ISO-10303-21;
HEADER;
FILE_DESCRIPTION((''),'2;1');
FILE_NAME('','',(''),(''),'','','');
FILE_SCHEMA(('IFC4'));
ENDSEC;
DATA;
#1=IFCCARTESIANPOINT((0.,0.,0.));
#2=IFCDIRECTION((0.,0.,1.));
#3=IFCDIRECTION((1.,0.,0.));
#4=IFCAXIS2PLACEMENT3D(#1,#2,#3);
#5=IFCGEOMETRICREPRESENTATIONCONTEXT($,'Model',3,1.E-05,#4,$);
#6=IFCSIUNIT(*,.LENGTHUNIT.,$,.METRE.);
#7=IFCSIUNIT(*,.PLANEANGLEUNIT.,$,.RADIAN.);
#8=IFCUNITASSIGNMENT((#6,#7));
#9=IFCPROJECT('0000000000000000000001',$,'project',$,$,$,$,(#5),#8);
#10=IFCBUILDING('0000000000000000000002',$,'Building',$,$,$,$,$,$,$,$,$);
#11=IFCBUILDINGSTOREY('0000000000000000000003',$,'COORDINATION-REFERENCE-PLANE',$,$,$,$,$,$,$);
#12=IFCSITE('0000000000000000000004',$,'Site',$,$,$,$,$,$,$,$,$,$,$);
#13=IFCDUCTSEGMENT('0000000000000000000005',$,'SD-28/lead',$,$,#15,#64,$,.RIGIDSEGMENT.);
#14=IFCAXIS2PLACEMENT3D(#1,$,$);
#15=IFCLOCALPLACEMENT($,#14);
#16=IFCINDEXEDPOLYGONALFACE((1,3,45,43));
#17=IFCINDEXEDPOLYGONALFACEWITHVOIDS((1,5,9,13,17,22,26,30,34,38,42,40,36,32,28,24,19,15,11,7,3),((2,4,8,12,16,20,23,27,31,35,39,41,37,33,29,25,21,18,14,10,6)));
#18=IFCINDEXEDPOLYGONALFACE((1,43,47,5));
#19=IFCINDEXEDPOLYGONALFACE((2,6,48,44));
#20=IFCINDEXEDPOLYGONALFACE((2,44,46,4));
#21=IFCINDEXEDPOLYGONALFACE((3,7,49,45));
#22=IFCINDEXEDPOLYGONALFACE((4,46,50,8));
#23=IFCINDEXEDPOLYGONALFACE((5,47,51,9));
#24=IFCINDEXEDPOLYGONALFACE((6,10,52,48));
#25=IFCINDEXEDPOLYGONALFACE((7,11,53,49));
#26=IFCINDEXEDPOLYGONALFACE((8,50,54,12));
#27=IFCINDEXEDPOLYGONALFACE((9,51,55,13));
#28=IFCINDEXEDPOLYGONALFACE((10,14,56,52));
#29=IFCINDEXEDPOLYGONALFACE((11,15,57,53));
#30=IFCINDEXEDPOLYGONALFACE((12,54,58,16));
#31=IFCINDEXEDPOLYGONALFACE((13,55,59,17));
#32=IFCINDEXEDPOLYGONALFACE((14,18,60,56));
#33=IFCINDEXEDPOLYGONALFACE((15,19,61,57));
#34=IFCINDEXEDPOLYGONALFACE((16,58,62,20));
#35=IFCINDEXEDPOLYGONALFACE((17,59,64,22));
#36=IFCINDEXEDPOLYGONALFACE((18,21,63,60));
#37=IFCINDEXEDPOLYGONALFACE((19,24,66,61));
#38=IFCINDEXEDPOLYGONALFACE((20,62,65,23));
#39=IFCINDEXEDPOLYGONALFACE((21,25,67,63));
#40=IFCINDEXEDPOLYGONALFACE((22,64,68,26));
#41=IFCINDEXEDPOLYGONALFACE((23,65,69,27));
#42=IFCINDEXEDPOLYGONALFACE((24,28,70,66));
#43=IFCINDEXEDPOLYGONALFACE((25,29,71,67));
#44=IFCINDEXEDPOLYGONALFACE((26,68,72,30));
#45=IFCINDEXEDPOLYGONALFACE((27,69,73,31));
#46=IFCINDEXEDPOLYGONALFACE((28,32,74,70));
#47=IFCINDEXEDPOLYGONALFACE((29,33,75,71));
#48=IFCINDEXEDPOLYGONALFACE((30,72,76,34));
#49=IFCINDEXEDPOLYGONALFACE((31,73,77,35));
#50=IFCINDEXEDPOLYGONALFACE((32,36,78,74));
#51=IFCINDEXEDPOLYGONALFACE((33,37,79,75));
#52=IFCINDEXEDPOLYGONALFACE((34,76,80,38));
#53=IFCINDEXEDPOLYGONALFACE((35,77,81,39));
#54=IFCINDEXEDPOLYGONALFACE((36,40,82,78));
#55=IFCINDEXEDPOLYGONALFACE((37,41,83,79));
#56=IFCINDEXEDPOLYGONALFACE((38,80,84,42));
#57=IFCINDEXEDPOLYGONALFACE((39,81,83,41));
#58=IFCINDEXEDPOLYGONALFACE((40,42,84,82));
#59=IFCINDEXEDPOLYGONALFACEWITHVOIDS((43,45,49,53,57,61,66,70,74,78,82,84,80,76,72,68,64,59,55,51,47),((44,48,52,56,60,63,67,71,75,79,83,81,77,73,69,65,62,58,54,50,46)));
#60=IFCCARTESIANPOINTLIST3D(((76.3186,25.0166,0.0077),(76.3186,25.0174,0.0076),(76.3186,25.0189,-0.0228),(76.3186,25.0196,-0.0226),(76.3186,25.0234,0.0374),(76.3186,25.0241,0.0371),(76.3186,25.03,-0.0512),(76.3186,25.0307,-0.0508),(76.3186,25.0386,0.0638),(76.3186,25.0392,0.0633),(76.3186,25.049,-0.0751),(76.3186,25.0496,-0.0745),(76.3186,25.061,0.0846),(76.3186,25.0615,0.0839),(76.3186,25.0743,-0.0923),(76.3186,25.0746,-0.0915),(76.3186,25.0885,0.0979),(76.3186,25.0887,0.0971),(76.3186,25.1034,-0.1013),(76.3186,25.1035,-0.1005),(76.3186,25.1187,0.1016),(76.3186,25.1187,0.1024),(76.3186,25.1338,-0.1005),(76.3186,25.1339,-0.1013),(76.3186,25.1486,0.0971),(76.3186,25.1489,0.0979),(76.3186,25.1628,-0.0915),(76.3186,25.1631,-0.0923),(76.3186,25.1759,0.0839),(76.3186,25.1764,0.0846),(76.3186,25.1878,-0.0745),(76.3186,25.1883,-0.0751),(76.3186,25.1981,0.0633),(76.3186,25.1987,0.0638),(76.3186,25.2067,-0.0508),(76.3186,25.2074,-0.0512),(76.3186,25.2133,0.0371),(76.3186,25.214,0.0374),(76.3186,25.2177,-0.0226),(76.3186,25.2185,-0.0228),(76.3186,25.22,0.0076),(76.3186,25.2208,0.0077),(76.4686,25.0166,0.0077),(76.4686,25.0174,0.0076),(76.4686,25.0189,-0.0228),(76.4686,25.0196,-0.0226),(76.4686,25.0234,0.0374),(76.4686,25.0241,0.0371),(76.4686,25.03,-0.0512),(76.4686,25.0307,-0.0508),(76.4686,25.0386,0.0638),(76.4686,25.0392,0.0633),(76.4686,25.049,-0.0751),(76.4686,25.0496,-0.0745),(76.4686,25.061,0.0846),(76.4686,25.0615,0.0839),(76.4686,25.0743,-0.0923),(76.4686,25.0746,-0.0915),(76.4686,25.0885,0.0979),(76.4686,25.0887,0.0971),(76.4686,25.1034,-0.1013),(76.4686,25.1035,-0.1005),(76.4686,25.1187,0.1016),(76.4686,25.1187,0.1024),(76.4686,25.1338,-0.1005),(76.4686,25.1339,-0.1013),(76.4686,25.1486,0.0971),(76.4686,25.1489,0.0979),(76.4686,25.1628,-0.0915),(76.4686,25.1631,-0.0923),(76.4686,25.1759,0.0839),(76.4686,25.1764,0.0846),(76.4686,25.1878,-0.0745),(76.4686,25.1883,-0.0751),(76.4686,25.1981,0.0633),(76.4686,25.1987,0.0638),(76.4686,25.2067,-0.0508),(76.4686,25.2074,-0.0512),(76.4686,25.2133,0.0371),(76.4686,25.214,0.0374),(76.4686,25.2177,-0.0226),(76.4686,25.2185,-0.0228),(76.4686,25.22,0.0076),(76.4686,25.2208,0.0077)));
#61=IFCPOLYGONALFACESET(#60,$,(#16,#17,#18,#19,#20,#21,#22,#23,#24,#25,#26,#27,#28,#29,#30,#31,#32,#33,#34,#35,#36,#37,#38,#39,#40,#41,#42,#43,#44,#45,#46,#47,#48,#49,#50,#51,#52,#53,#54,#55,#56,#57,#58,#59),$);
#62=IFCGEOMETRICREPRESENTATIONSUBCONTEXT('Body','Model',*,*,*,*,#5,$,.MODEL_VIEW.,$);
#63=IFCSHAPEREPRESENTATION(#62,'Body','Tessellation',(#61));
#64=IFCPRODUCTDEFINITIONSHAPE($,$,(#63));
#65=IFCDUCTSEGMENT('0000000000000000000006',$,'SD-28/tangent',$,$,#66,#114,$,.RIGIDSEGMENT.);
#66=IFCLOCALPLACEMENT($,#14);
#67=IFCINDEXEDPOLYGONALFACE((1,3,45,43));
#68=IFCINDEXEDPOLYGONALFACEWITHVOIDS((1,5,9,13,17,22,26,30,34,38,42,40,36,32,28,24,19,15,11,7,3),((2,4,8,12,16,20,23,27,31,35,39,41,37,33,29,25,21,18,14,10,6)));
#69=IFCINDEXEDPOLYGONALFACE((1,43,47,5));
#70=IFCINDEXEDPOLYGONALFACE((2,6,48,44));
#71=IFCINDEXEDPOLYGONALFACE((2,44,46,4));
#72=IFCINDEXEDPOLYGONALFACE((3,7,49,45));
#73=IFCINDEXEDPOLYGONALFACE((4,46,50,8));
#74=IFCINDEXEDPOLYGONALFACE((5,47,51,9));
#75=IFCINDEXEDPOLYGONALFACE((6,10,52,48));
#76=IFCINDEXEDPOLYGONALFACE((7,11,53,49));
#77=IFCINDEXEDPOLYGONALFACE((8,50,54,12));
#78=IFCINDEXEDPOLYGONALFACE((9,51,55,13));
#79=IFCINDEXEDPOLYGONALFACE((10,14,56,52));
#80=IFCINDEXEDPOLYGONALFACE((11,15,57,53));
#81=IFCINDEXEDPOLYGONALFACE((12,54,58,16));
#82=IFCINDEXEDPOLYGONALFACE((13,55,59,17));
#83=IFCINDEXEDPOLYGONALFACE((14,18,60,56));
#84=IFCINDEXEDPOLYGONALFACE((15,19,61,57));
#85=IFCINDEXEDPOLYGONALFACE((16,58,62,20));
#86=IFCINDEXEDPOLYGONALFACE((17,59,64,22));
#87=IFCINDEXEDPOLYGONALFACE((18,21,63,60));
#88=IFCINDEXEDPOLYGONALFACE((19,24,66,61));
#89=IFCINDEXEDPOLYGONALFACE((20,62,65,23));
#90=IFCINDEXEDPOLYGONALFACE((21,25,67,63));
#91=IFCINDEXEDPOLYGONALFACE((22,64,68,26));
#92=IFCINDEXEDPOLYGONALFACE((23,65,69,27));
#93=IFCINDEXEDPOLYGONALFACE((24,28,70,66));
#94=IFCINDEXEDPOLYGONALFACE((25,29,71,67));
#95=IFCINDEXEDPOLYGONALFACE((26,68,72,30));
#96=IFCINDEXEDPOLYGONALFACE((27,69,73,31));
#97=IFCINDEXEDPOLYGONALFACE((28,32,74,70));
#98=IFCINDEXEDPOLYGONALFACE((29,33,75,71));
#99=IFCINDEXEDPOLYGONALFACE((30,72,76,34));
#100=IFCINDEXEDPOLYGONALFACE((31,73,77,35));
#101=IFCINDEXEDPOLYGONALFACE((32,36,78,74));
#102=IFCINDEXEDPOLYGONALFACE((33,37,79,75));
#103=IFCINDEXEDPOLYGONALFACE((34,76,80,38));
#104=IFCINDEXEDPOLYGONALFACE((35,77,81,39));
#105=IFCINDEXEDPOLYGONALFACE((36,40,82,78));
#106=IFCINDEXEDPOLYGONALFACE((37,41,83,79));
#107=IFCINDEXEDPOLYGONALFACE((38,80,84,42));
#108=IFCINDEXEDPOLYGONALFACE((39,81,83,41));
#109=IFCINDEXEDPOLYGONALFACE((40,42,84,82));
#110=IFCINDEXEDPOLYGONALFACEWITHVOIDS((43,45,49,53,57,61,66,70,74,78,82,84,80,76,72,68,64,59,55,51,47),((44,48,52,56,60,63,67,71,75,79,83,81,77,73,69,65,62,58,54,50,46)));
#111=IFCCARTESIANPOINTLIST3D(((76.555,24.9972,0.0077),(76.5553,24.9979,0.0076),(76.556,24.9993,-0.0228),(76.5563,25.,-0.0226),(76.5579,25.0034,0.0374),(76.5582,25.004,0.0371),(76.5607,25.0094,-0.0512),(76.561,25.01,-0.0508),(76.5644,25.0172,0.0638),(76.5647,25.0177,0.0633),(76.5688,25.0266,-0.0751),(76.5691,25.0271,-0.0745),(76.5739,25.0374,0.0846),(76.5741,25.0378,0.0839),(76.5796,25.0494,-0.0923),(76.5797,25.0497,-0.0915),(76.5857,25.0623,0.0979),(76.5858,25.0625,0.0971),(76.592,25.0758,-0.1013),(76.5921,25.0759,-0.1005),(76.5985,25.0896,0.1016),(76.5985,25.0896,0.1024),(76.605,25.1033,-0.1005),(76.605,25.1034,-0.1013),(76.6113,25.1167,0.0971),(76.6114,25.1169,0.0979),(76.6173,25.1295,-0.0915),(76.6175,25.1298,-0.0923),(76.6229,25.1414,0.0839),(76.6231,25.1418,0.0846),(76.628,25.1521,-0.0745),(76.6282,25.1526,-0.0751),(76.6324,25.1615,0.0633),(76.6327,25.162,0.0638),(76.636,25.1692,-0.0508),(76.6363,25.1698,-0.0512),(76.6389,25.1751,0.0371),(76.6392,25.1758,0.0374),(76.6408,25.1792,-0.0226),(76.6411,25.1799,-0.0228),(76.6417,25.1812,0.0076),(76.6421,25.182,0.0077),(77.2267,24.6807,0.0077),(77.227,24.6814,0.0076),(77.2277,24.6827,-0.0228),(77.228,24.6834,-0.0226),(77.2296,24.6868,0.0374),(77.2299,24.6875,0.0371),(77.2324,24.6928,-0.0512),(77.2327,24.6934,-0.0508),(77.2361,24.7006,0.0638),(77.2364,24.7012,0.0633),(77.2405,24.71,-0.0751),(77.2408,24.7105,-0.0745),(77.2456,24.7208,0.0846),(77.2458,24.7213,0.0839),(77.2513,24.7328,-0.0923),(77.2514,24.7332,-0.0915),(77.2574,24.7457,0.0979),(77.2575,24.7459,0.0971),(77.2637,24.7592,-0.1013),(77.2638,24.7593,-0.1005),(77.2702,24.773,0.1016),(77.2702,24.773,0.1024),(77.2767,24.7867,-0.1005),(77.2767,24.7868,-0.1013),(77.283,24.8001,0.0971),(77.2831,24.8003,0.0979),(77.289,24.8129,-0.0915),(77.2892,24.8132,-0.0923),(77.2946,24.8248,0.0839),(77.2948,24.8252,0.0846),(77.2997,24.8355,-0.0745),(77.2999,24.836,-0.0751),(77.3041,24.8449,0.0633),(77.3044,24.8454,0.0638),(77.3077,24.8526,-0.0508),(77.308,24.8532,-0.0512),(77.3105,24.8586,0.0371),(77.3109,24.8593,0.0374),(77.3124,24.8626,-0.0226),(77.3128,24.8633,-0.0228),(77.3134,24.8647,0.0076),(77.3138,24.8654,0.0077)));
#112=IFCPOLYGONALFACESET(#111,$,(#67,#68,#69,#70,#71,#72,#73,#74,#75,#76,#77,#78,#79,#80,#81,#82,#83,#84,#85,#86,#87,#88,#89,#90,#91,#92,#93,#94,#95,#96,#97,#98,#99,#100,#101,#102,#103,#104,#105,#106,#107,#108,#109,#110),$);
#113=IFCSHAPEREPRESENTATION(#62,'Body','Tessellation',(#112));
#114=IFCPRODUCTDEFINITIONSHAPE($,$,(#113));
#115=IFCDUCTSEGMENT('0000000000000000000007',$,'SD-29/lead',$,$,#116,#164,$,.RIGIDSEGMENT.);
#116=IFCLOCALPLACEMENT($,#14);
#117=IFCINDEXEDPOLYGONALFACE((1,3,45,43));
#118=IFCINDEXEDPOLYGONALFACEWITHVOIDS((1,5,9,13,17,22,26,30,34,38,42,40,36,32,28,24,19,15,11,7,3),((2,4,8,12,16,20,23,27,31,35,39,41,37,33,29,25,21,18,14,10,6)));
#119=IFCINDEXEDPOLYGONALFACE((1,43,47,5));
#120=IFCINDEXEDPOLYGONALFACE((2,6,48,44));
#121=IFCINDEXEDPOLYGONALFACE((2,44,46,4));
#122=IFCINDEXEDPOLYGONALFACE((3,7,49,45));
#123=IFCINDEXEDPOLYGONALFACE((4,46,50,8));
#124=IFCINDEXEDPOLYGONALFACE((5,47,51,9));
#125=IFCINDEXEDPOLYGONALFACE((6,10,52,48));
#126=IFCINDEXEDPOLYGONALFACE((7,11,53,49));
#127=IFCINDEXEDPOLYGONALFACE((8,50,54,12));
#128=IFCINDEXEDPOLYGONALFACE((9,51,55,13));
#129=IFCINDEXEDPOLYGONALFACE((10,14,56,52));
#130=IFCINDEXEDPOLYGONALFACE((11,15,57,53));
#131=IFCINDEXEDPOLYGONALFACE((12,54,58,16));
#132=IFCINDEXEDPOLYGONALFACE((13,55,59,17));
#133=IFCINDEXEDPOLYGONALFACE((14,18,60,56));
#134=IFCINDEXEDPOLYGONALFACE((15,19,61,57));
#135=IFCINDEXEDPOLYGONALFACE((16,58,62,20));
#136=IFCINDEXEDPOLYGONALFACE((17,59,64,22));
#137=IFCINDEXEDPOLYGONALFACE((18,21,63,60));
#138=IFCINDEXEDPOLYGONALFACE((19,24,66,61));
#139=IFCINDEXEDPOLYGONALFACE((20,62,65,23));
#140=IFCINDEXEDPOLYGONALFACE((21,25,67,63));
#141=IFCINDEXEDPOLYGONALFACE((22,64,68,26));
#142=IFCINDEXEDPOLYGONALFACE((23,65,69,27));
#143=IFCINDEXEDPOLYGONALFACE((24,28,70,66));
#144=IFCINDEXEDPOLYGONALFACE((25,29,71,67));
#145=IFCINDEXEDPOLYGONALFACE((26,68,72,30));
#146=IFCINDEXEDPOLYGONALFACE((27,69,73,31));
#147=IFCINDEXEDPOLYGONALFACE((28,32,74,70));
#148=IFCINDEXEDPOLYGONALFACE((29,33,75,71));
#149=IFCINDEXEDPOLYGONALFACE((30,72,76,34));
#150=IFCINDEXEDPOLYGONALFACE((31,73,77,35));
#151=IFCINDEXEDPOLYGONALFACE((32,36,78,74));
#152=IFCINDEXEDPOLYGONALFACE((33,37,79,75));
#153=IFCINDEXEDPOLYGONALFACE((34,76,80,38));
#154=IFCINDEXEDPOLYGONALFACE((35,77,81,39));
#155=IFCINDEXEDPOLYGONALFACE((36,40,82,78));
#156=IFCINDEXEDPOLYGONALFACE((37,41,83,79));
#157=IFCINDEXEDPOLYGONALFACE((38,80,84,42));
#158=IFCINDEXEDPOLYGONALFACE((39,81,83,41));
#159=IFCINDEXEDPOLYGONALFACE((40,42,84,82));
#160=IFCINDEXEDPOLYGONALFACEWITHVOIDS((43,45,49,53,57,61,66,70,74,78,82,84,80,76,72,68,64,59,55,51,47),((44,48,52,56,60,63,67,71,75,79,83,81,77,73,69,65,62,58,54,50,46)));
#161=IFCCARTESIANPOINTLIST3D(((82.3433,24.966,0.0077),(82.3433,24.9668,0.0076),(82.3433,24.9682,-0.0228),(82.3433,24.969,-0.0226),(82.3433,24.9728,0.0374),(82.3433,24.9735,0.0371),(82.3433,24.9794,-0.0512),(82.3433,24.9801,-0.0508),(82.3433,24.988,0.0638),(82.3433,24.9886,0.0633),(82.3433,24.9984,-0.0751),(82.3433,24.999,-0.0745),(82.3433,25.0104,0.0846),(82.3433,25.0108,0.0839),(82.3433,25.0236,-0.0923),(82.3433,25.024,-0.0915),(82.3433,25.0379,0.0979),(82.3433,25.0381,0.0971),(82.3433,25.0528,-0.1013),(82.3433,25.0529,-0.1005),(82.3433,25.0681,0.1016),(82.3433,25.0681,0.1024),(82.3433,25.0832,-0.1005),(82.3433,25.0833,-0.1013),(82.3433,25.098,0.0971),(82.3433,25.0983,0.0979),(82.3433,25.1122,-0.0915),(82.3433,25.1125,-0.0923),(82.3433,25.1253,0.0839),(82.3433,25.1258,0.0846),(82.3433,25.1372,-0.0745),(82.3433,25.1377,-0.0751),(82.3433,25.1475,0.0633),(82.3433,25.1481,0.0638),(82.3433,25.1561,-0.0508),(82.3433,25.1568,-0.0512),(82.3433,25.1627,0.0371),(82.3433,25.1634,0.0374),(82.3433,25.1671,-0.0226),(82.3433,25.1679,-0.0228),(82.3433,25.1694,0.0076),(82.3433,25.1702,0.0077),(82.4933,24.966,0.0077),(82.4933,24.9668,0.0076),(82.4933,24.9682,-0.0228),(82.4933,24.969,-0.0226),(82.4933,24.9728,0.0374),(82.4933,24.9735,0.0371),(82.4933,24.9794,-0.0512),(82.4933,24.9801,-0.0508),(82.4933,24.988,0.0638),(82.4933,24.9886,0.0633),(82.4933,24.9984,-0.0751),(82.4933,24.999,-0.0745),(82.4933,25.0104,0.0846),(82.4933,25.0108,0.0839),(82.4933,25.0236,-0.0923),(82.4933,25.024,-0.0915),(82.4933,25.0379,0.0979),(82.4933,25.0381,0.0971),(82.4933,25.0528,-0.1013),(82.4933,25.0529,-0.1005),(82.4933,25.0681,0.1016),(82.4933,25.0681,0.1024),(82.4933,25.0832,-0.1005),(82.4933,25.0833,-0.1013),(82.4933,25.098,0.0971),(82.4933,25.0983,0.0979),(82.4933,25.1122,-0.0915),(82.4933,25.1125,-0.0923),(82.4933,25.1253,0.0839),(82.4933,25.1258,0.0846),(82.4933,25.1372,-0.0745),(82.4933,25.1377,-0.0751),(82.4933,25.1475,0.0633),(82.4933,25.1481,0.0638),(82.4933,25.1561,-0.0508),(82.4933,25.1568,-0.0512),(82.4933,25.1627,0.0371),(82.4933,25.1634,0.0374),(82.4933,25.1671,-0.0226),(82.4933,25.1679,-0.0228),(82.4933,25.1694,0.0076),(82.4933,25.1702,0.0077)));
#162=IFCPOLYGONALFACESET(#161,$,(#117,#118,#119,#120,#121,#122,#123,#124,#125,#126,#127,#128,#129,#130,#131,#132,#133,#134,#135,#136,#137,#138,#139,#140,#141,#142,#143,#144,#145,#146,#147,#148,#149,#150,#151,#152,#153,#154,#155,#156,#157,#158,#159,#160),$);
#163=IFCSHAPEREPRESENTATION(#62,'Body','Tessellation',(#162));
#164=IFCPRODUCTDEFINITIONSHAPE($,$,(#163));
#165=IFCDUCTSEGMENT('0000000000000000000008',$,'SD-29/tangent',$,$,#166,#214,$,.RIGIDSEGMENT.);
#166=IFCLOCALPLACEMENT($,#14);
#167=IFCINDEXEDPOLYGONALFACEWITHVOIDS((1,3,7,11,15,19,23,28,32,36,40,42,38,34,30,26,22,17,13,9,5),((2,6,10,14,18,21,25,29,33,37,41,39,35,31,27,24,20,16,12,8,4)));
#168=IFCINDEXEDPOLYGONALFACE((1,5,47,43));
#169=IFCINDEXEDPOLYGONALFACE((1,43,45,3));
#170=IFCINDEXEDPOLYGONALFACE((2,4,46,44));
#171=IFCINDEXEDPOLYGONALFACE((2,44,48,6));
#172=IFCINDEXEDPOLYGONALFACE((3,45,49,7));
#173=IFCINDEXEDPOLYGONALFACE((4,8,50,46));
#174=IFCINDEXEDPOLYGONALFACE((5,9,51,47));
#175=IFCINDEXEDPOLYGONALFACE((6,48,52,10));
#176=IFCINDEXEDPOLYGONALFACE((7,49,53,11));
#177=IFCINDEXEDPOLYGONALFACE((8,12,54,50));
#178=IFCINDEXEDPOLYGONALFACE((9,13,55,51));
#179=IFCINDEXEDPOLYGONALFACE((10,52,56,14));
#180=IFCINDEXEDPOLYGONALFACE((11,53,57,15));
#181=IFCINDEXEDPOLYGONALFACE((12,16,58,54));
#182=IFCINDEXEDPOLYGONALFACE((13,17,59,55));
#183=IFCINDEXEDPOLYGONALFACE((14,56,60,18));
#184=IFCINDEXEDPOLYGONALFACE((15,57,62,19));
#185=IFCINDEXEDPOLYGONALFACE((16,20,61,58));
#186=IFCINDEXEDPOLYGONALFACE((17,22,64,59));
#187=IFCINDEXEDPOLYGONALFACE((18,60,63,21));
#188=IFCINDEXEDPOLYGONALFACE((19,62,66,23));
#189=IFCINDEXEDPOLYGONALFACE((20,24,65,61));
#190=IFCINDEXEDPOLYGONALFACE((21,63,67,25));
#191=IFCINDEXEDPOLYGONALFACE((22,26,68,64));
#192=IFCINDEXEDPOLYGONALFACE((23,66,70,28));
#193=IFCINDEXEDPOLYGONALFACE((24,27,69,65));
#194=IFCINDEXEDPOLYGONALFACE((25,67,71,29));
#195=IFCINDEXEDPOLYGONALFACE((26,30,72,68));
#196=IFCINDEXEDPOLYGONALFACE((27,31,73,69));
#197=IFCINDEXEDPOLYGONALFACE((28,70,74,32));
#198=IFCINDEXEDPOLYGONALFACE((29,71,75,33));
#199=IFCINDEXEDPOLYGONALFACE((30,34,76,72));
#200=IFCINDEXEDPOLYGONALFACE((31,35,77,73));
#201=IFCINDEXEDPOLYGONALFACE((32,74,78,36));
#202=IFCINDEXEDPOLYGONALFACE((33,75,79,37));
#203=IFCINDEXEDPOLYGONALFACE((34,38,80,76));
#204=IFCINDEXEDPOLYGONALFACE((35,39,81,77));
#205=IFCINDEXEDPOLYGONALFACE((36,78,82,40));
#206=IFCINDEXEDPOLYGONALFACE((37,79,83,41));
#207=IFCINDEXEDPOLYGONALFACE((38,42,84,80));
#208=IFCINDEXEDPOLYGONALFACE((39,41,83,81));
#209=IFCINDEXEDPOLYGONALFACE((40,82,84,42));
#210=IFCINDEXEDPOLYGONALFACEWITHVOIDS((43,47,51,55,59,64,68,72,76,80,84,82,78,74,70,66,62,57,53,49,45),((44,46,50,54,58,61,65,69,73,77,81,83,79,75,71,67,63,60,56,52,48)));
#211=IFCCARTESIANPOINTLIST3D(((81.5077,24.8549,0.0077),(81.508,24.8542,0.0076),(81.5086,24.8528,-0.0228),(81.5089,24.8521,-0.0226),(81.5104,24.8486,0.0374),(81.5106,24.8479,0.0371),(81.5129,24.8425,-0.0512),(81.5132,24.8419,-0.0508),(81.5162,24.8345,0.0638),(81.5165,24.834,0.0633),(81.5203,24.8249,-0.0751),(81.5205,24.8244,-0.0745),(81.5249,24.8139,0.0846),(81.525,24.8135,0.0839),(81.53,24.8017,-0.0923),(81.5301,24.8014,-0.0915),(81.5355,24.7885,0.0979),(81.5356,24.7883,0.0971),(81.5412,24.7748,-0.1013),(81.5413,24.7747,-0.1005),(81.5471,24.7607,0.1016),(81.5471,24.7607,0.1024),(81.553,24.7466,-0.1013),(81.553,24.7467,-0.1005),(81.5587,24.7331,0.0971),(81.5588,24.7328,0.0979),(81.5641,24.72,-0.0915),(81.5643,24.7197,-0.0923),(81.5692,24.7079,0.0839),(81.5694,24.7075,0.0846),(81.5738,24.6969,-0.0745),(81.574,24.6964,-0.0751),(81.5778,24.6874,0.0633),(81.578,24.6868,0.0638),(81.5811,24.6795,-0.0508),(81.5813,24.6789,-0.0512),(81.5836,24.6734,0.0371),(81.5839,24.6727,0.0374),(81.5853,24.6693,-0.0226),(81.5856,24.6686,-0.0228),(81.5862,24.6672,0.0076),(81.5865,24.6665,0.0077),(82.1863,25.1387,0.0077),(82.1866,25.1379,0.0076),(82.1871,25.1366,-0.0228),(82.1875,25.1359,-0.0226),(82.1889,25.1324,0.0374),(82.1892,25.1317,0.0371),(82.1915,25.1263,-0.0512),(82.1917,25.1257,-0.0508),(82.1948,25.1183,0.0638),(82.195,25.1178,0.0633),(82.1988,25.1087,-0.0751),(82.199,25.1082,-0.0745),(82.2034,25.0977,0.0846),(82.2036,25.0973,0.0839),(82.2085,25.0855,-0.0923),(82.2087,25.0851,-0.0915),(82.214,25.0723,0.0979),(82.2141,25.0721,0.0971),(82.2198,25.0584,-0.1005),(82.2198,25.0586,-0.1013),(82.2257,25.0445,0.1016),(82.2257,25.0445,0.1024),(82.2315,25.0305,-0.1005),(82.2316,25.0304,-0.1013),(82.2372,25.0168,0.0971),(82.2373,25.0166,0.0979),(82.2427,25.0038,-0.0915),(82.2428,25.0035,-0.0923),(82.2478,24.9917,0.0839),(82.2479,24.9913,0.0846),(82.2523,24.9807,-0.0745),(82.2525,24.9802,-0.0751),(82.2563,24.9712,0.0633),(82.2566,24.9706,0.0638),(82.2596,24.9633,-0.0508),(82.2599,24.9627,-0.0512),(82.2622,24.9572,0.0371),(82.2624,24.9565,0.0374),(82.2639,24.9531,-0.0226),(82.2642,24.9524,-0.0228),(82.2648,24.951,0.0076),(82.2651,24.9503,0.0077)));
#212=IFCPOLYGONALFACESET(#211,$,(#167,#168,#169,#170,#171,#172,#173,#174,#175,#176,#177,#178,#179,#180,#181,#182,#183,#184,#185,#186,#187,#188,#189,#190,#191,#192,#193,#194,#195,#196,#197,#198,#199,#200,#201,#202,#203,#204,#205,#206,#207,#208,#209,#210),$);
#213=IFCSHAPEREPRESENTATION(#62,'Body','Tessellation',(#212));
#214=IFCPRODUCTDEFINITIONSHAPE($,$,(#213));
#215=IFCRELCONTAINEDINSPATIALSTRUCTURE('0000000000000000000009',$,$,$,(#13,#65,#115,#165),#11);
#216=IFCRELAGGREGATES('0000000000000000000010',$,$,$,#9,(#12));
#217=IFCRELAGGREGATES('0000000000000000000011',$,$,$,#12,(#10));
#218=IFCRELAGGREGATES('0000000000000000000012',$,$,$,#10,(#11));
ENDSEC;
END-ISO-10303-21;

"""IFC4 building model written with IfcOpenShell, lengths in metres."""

from ifc_helpers import new_model, si_unit, frame, origin_with_axes, place, context, subcontext, project, spatial, hollow_circle, extrude, element, save


model = new_model("IFC4")

# Units and contexts
model_context_1 = context("Model", 3, precision=1e-05, world=origin_with_axes())
body_context_1 = subcontext(model_context_1, "Body", "Model", "MODEL_VIEW")
ifc_project = project(units=[si_unit("LENGTHUNIT", "METRE"), si_unit("PLANEANGLEUNIT", "RADIAN")], contexts=[model_context_1])

# Site, building, storey
site = spatial("IfcSite", under=ifc_project, Name="Site")
building = spatial("IfcBuilding", under=site, Name="Building")
storey = spatial("IfcBuildingStorey", under=building, Name="COORDINATION-REFERENCE-PLANE")

# Duct segment
duct_segment_1_placement = place(None, frame((76.3186, 25.1187, 0.0), z_axis=(1.0, 0.0, 0.0), x_axis=(0.0, 0.0, 1.0)))
element("IfcDuctSegment", 1, at=duct_segment_1_placement, inside=storey, Name="SD-28/lead", PredefinedType="RIGIDSEGMENT", context=body_context_1, shape_type="SweptSolid", body=[
    extrude(hollow_circle(Radius=0.1024, WallThickness=0.0008), origin_with_axes(), (0.0, 0.0, 1.0), 0.15),
])

# Duct segment
duct_segment_2_placement = place(None, frame((76.5985, 25.0896, 0.0), z_axis=(0.904569, -0.426327, 0.0), x_axis=(0.0, 0.0, 1.0)))
element("IfcDuctSegment", 2, at=duct_segment_2_placement, inside=storey, Name="SD-28/tangent", PredefinedType="RIGIDSEGMENT", context=body_context_1, shape_type="SweptSolid", body=[
    extrude(hollow_circle(Radius=0.1024, WallThickness=0.0008), origin_with_axes(), (0.0, 0.0, 1.0), 0.7425),
])

# Duct segment
duct_segment_3_placement = place(None, frame((82.4933, 25.0681, 0.0), z_axis=(-1.0, 0.0, 0.0), x_axis=(0.0, 0.0, 1.0)))
element("IfcDuctSegment", 3, at=duct_segment_3_placement, inside=storey, Name="SD-29/lead", PredefinedType="RIGIDSEGMENT", context=body_context_1, shape_type="SweptSolid", body=[
    extrude(hollow_circle(Radius=0.1024, WallThickness=0.0008), origin_with_axes(), (0.0, 0.0, 1.0), 0.15),
])

# Duct segment
duct_segment_4_placement = place(None, frame((82.2257, 25.0445, 0.0), z_axis=(-0.922564, -0.385845, 0.0), x_axis=(0.0, 0.0, 1.0)))
element("IfcDuctSegment", 4, at=duct_segment_4_placement, inside=storey, Name="SD-29/tangent", PredefinedType="RIGIDSEGMENT", context=body_context_1, shape_type="SweptSolid", body=[
    extrude(hollow_circle(Radius=0.1024, WallThickness=0.0008), origin_with_axes(), (0.0, 0.0, 1.0), 0.7355),
])

save(model, "model.ifc")
